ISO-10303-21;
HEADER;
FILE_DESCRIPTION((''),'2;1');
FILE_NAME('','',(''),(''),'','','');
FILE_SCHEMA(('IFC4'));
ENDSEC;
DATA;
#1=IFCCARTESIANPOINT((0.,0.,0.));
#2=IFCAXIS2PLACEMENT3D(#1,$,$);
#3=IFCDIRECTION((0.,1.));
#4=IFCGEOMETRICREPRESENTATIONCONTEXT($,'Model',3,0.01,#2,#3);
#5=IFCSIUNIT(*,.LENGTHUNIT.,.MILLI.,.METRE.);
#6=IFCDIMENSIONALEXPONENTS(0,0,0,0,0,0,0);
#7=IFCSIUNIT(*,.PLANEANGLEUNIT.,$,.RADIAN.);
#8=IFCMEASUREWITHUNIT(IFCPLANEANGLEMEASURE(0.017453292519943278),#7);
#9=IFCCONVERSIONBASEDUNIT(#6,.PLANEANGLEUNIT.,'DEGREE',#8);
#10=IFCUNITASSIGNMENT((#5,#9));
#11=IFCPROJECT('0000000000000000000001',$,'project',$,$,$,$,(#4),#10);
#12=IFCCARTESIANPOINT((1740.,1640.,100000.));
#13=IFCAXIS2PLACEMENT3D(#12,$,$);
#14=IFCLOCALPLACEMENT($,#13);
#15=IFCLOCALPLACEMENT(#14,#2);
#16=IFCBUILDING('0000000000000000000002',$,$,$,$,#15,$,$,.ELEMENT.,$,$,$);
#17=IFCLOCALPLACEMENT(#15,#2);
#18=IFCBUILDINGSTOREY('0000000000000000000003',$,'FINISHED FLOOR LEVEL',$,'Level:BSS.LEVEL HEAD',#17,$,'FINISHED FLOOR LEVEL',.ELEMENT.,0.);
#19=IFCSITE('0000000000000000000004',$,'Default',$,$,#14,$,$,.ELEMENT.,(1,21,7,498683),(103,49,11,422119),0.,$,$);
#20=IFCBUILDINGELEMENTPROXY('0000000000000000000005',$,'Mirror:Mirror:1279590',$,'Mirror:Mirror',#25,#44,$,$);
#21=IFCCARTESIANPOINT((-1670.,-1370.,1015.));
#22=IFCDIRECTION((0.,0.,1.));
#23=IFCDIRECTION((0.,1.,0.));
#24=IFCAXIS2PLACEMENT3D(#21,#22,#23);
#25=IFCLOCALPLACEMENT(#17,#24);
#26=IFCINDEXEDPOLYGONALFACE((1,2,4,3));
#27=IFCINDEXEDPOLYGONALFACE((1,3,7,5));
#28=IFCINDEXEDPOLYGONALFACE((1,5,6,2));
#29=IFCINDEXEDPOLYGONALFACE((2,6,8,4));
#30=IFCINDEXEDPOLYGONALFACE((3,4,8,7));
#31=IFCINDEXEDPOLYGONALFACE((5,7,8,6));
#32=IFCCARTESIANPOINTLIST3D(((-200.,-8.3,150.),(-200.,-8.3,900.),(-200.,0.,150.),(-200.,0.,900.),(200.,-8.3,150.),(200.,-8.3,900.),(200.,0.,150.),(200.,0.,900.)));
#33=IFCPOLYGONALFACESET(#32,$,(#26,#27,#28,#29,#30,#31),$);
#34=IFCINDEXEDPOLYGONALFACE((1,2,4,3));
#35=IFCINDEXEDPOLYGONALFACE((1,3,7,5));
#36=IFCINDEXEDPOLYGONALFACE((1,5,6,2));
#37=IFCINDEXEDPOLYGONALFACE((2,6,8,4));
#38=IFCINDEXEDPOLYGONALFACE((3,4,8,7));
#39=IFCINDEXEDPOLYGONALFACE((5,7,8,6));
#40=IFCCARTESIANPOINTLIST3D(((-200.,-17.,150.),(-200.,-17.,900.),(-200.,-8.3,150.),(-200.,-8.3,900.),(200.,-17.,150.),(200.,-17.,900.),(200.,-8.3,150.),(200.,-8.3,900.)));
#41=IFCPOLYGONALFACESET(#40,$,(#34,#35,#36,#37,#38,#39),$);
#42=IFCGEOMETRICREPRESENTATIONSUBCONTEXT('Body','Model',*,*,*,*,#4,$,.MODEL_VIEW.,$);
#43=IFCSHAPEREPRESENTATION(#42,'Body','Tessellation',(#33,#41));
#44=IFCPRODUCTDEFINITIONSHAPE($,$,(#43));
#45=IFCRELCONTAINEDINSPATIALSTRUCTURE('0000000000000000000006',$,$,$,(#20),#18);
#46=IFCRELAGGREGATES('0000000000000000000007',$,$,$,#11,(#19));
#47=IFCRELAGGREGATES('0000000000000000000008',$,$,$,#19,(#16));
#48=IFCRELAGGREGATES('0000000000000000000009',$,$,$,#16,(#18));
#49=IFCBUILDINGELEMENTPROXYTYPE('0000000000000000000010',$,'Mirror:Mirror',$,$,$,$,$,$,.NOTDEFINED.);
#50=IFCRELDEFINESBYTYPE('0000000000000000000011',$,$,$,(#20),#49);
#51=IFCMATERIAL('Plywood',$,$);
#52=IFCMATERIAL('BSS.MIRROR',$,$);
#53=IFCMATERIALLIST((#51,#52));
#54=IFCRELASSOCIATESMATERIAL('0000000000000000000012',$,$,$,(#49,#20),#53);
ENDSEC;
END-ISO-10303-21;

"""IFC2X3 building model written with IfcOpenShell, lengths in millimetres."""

from ifc_helpers import new_model, entity, si_unit, converted_unit, direction, frame, origin, origin_2d_with_axis, place, context, subcontext, project, spatial, rectangle, extrude, source, transform, mapped, material, material_list, type_object, type_shapes, element, save


model = new_model("IFC2X3")

# Units and contexts
model_context = context("Model", 3, precision=0.01, world=origin(), true_north=direction((0.0, 1.0)))
body_context = subcontext(model_context, "Body", "Model", "MODEL_VIEW")
ifc_project = project(units=[si_unit("LENGTHUNIT", "METRE", prefix="MILLI"), converted_unit("PLANEANGLEUNIT", "DEGREE", entity("IfcPlaneAngleMeasure", 0.017453292519943278), si_unit("PLANEANGLEUNIT", "RADIAN"), dimensions=[0, 0, 0, 0, 0, 0, 0])], contexts=[model_context])

# Site, building, storey
site_placement = place(None, frame((1740.0, 1640.0, 100000.0)))
site = spatial("IfcSite", under=ifc_project, at=site_placement, Name="Default", CompositionType="ELEMENT", RefLatitude=(1, 21, 7, 498683), RefLongitude=(103, 49, 11, 422119), RefElevation=0.0)
building_placement = place(site_placement, origin())
building = spatial("IfcBuilding", under=site, at=building_placement, CompositionType="ELEMENT")
storey_placement = place(building_placement, origin())
storey = spatial("IfcBuildingStorey", under=building, at=storey_placement, Name="FINISHED FLOOR LEVEL", ObjectType="Level:BSS.LEVEL HEAD", LongName="FINISHED FLOOR LEVEL", CompositionType="ELEMENT", Elevation=0.0)

# Building element proxy
ifc_material_1 = material(Name="Plywood")
ifc_material_2 = material(Name="BSS.MIRROR")
ifc_material_list = material_list([ifc_material_1, ifc_material_2])
building_element_proxy_type = type_object("IfcBuildingElementProxyType", Name="Mirror:Mirror", PredefinedType="NOTDEFINED", material=ifc_material_list)
shared_shape = source(origin(), body_context, "Body", "SweptSolid", [
    extrude(rectangle(XDim=8.3, YDim=400.0, at=origin_2d_with_axis()), frame((0.0, -4.1, 150.0), z_axis=(0.0, 0.0, 1.0), x_axis=(0.0, 1.0, 0.0)), (0.0, 0.0, 1.0), 750.0),
    extrude(rectangle(XDim=8.7, YDim=400.0, at=origin_2d_with_axis()), frame((0.0, -12.6, 150.0), z_axis=(0.0, 0.0, 1.0), x_axis=(0.0, 1.0, 0.0)), (0.0, 0.0, 1.0), 750.0),
])
type_shapes(building_element_proxy_type, [shared_shape])
proxy_placement = place(storey_placement, frame((-1670.0, -1370.0, 1015.0), z_axis=(0.0, 0.0, 1.0), x_axis=(0.0, 1.0, 0.0)))
element("IfcBuildingElementProxy", 1, at=proxy_placement, inside=storey, type_object=building_element_proxy_type, material=ifc_material_list, Name="Mirror:Mirror:1279590", ObjectType="Mirror:Mirror", context=body_context, shape_type="MappedRepresentation", body=[
    mapped(shared_shape, transform((0.0, 0.0, 0.0), scale=1.0)),
])

save(model, "model.ifc")
